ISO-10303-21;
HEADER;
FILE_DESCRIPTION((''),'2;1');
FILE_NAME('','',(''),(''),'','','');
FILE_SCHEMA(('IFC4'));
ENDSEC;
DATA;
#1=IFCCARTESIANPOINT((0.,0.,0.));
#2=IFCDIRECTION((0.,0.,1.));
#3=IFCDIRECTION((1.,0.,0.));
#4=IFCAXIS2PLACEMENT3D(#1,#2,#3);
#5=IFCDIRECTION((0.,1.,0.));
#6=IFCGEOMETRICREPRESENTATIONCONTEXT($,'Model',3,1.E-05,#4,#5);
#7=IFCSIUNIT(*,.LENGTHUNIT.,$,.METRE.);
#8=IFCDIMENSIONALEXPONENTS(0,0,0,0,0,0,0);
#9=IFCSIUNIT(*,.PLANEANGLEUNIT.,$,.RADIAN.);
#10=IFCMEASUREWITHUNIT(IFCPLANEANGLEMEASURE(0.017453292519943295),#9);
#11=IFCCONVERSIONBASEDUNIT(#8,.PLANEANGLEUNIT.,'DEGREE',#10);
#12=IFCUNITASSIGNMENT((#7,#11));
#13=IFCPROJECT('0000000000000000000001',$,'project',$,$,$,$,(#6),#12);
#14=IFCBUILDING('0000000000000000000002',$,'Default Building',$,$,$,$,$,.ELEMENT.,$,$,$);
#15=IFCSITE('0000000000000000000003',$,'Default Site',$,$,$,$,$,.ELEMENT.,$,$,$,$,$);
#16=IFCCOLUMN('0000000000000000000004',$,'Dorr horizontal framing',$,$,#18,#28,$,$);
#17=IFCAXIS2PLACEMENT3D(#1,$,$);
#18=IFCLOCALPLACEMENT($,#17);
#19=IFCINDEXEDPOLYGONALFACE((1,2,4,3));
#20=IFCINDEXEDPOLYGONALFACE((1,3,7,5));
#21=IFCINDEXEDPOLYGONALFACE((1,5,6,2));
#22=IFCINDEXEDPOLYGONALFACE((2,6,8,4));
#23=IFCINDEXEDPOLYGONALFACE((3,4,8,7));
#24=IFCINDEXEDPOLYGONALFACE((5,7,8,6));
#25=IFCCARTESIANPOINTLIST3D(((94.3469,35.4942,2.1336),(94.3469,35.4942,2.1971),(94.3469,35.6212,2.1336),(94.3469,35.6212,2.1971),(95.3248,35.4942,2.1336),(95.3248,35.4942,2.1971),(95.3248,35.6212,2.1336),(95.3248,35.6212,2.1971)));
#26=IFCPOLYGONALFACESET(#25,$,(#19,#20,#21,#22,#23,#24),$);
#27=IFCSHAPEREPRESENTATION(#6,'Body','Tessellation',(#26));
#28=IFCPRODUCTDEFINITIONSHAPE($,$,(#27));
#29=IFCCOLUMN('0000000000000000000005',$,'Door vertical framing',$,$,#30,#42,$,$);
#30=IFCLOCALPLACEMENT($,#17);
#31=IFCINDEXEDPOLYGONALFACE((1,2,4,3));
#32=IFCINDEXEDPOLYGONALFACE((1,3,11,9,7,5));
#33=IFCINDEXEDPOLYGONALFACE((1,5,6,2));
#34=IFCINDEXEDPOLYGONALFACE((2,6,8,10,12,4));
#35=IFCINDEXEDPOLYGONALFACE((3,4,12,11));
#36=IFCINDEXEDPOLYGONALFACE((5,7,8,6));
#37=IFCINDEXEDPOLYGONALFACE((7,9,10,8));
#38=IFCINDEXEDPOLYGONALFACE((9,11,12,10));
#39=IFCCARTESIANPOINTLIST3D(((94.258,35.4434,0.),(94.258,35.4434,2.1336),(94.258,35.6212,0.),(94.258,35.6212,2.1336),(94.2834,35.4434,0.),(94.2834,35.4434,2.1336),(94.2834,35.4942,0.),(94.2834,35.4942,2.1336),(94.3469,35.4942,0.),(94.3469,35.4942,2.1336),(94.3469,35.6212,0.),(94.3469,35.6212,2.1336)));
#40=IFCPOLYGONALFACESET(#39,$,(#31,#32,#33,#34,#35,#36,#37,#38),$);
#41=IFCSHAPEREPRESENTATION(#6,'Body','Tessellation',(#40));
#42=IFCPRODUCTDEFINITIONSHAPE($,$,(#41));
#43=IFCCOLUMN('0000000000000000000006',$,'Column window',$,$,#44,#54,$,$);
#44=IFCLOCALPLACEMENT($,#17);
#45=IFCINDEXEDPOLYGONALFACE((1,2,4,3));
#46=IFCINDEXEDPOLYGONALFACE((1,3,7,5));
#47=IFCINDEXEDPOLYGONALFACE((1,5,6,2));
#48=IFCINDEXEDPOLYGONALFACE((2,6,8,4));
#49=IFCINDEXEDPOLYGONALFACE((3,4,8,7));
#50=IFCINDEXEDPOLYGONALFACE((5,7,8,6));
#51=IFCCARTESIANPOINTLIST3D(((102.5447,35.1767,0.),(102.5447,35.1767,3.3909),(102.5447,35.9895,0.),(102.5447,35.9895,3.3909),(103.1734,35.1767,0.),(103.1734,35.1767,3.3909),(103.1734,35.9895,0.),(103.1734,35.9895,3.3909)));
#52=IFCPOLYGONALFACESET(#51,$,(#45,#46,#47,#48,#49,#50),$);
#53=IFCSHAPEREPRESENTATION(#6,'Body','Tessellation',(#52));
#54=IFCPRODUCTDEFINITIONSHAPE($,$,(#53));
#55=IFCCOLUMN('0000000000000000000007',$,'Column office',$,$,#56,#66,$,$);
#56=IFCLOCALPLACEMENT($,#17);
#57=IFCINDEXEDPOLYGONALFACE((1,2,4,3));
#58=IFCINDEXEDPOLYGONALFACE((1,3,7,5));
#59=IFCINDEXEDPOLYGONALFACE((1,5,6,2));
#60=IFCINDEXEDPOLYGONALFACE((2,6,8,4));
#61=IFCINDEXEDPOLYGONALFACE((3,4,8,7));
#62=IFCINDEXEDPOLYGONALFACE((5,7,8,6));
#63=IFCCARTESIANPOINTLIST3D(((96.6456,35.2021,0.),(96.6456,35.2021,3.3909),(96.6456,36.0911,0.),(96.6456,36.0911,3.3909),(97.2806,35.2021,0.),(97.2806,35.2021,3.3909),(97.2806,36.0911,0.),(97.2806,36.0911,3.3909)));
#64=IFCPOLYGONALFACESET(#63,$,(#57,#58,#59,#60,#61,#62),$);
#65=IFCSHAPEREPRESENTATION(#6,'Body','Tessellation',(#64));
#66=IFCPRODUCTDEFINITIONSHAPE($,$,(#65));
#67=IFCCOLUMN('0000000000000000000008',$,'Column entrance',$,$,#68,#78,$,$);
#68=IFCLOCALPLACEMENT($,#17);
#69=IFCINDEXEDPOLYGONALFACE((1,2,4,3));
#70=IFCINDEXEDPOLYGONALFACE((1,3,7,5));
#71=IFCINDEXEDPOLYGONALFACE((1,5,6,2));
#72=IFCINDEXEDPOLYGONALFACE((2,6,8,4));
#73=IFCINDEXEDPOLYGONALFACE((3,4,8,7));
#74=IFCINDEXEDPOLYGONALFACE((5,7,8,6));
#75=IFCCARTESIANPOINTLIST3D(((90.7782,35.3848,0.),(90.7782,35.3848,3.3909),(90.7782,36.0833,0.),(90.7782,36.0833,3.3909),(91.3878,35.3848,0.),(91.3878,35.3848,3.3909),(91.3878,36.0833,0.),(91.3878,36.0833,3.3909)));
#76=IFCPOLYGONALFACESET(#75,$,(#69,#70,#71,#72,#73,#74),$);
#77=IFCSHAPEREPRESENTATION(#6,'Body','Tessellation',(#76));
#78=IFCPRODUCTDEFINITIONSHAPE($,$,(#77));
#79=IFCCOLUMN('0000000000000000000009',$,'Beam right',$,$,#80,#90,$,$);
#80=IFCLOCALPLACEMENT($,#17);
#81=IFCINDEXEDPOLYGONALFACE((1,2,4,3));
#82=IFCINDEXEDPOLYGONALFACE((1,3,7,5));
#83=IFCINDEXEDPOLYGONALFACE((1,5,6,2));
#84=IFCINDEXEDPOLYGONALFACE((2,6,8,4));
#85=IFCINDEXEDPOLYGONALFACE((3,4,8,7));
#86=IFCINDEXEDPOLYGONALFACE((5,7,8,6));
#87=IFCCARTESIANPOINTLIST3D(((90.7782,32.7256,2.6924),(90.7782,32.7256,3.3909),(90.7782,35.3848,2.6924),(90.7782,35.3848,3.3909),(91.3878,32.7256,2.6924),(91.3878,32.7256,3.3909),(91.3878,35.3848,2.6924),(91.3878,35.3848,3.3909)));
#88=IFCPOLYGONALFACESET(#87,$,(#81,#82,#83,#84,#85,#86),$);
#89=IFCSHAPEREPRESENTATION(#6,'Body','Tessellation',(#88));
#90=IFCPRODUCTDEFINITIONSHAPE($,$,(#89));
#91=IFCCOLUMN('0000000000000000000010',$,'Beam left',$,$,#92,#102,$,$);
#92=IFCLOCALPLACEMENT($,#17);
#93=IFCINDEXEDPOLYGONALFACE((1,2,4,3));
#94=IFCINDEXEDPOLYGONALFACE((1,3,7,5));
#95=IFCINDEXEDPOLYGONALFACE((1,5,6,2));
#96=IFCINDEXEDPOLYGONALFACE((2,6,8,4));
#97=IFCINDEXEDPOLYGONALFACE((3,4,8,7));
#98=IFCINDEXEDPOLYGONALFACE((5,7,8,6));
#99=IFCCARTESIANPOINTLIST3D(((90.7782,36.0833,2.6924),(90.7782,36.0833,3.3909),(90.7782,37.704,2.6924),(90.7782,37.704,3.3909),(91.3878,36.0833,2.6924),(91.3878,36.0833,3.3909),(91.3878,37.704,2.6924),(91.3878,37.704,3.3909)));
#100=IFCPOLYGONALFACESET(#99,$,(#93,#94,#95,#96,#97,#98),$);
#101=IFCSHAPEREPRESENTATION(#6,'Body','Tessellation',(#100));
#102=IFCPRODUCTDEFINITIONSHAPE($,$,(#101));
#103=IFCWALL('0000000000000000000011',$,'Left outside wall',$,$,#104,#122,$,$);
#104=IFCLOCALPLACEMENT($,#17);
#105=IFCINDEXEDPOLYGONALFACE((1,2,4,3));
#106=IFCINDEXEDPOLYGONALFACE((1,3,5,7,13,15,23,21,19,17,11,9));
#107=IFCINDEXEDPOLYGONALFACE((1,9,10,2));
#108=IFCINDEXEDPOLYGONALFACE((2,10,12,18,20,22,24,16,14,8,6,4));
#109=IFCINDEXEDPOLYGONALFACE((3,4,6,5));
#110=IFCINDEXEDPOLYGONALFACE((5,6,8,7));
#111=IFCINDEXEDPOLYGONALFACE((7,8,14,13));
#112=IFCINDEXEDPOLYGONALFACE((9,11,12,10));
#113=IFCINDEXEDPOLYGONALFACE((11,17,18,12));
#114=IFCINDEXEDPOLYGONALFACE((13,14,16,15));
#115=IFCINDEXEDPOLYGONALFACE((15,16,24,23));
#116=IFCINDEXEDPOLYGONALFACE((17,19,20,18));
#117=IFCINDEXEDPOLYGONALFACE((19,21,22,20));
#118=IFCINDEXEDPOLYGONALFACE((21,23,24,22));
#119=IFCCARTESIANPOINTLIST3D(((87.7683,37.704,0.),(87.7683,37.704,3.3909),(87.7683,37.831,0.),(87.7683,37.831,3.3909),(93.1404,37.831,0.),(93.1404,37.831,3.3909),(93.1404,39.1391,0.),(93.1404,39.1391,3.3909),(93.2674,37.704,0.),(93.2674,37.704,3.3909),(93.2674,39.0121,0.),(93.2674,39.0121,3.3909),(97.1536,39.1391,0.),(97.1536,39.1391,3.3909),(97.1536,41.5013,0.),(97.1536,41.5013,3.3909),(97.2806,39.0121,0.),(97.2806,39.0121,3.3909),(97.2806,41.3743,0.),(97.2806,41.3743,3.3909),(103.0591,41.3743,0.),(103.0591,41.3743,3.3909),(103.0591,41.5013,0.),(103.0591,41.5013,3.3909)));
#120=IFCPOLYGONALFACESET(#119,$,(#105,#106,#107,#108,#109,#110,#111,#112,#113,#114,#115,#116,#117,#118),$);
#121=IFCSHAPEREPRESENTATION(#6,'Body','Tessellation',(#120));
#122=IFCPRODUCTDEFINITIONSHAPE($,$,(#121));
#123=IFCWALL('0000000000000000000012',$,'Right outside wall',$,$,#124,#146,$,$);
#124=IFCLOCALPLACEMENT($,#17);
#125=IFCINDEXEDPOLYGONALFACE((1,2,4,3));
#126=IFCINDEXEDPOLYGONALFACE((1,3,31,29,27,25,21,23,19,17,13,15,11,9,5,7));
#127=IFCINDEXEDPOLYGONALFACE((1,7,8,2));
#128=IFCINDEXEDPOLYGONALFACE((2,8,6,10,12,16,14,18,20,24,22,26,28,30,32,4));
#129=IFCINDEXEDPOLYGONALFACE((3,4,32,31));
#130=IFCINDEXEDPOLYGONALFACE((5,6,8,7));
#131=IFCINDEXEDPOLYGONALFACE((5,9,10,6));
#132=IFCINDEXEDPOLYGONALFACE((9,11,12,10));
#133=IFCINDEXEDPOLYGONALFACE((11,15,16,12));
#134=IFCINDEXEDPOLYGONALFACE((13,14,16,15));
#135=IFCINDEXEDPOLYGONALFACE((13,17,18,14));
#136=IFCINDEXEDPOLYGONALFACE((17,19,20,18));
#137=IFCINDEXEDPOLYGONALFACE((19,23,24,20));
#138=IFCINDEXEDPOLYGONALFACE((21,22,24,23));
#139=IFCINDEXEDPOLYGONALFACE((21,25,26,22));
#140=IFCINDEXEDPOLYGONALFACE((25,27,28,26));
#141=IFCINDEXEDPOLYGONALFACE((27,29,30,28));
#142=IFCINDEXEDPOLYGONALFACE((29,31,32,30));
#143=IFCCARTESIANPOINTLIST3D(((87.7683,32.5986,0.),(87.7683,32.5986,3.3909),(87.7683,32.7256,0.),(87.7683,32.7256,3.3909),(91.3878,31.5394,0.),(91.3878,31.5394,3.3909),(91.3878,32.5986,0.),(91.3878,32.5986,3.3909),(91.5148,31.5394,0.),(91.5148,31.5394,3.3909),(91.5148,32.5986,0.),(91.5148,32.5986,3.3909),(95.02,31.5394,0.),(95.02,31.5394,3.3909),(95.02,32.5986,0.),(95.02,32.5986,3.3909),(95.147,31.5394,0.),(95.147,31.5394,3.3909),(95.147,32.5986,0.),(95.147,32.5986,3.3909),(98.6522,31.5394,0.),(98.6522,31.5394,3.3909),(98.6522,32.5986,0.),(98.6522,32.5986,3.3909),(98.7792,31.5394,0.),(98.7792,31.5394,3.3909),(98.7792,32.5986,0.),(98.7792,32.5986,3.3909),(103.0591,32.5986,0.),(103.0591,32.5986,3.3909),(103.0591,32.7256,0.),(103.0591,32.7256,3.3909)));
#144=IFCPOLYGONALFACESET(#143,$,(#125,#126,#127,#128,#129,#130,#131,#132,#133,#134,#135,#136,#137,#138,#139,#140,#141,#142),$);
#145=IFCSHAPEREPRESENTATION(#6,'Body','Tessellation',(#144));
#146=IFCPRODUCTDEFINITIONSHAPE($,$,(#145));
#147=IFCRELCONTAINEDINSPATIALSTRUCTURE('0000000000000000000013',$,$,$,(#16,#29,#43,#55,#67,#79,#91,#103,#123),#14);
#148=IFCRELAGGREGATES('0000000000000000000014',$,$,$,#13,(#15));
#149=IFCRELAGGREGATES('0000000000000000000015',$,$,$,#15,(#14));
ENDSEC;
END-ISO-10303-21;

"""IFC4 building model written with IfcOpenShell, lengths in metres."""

from ifc_helpers import new_model, entity, si_unit, converted_unit, direction, frame, origin_with_axes, place, context, project, spatial, polyline, outline, extrude, element, save


model = new_model("IFC4")

# Units and contexts
model_context = context("Model", 3, precision=1e-05, world=origin_with_axes(), true_north=direction((0.0, 1.0, 0.0)))
ifc_project = project(units=[si_unit("LENGTHUNIT", "METRE"), converted_unit("PLANEANGLEUNIT", "DEGREE", entity("IfcPlaneAngleMeasure", 0.017453292519943295), si_unit("PLANEANGLEUNIT", "RADIAN"), dimensions=[0, 0, 0, 0, 0, 0, 0])], contexts=[model_context])

# Site, building
site = spatial("IfcSite", under=ifc_project, Name="Default Site", CompositionType="ELEMENT")
building = spatial("IfcBuilding", under=site, Name="Default Building", CompositionType="ELEMENT")

# Columns
column_1_placement = place(None, origin_with_axes())
element("IfcColumn", 1, at=column_1_placement, inside=building, Name="Dorr horizontal framing", context=model_context, shape_type="SweptSolid", body=[
    extrude(outline(polyline([(0.0, 0.0), (0.127, 0.0), (0.127, 0.0635), (0.0, 0.0635), (0.0, 0.0)])), frame((94.3469, 35.4942, 2.1336), z_axis=(1.0, 0.0, 0.0), x_axis=(0.0, 1.0, 0.0)), (0.0, 0.0, 1.0), 0.9779),
])
column_2_placement = place(None, origin_with_axes())
element("IfcColumn", 2, at=column_2_placement, inside=building, Name="Door vertical framing", context=model_context, shape_type="SweptSolid", body=[
    extrude(outline(polyline([(94.258, 35.6212), (94.3469, 35.6212), (94.3469, 35.4942), (94.2834, 35.4942), (94.2834, 35.4434), (94.258, 35.4434), (94.258, 35.6212)])), origin_with_axes(), (0.0, 0.0, 1.0), 2.1336),
])
column_3_placement = place(None, origin_with_axes())
element("IfcColumn", 3, at=column_3_placement, inside=building, Name="Column window", context=model_context, shape_type="SweptSolid", body=[
    extrude(outline(polyline([(0.0, 0.0), (0.6286, 0.0), (0.6286, -0.8128), (0.0, -0.8128), (0.0, 0.0)])), frame((102.5447, 35.9895, 0.0), z_axis=(0.0, 0.0, 1.0), x_axis=(1.0, 0.0, 0.0)), (0.0, 0.0, 1.0), 3.3909),
])
column_4_placement = place(None, origin_with_axes())
element("IfcColumn", 4, at=column_4_placement, inside=building, Name="Column office", context=model_context, shape_type="SweptSolid", body=[
    extrude(outline(polyline([(0.0, 0.0), (0.635, 0.0), (0.635, -0.889), (0.0, -0.889), (0.0, 0.0)])), frame((96.6456, 36.0911, 0.0), z_axis=(0.0, 0.0, 1.0), x_axis=(1.0, 0.0, 0.0)), (0.0, 0.0, 1.0), 3.3909),
])
column_5_placement = place(None, origin_with_axes())
element("IfcColumn", 5, at=column_5_placement, inside=building, Name="Column entrance", context=model_context, shape_type="SweptSolid", body=[
    extrude(outline(polyline([(0.0, 0.0), (0.6096, 0.0), (0.6096, -0.6985), (0.0, -0.6985), (0.0, 0.0)])), frame((90.7782, 36.0833, 0.0), z_axis=(0.0, 0.0, 1.0), x_axis=(1.0, 0.0, 0.0)), (0.0, 0.0, 1.0), 3.3909),
])
column_6_placement = place(None, origin_with_axes())
element("IfcColumn", 6, at=column_6_placement, inside=building, Name="Beam right", context=model_context, shape_type="SweptSolid", body=[
    extrude(outline(polyline([(0.0, 0.0), (0.6096, 0.0), (0.6096, 2.6592), (0.0, 2.6592), (0.0, 0.0)])), frame((90.7782, 32.7256, 3.3909), z_axis=(0.0, 0.0, 1.0), x_axis=(1.0, 0.0, 0.0)), (0.0, 0.0, -1.0), 0.6985),
])
column_7_placement = place(None, origin_with_axes())
element("IfcColumn", 7, at=column_7_placement, inside=building, Name="Beam left", context=model_context, shape_type="SweptSolid", body=[
    extrude(outline(polyline([(0.0, 0.0), (0.6096, 0.0), (0.6096, -1.6207), (0.0, -1.6207), (0.0, 0.0)])), frame((90.7782, 37.704, 3.3909), z_axis=(0.0, 0.0, 1.0), x_axis=(1.0, 0.0, 0.0)), (0.0, 0.0, -1.0), 0.6985),
])

# Walls
wall_1_placement = place(None, origin_with_axes())
element("IfcWall", 8, at=wall_1_placement, inside=building, Name="Left outside wall", context=model_context, shape_type="SweptSolid", body=[
    extrude(outline(polyline([(87.7683, 37.831), (87.7683, 37.704), (93.2674, 37.704), (93.2674, 39.0121), (97.2806, 39.0121), (97.2806, 41.3743), (103.0591, 41.3743), (103.0591, 41.5013), (97.1536, 41.5013), (97.1536, 39.1391), (93.1404, 39.1391), (93.1404, 37.831), (87.7683, 37.831)])), origin_with_axes(), (0.0, 0.0, 1.0), 3.3909),
])
wall_2_placement = place(None, origin_with_axes())
element("IfcWall", 9, at=wall_2_placement, inside=building, Name="Right outside wall", context=model_context, shape_type="SweptSolid", body=[
    extrude(outline(polyline([(87.7683, 32.5986), (87.7683, 32.7256), (103.0591, 32.7256), (103.0591, 32.5986), (98.7792, 32.5986), (98.7792, 31.5394), (98.6522, 31.5394), (98.6522, 32.5986), (95.147, 32.5986), (95.147, 31.5394), (95.02, 31.5394), (95.02, 32.5986), (91.5148, 32.5986), (91.5148, 31.5394), (91.3878, 31.5394), (91.3878, 32.5986), (87.7683, 32.5986)])), origin_with_axes(), (0.0, 0.0, 1.0), 3.3909),
])

save(model, "model.ifc")
